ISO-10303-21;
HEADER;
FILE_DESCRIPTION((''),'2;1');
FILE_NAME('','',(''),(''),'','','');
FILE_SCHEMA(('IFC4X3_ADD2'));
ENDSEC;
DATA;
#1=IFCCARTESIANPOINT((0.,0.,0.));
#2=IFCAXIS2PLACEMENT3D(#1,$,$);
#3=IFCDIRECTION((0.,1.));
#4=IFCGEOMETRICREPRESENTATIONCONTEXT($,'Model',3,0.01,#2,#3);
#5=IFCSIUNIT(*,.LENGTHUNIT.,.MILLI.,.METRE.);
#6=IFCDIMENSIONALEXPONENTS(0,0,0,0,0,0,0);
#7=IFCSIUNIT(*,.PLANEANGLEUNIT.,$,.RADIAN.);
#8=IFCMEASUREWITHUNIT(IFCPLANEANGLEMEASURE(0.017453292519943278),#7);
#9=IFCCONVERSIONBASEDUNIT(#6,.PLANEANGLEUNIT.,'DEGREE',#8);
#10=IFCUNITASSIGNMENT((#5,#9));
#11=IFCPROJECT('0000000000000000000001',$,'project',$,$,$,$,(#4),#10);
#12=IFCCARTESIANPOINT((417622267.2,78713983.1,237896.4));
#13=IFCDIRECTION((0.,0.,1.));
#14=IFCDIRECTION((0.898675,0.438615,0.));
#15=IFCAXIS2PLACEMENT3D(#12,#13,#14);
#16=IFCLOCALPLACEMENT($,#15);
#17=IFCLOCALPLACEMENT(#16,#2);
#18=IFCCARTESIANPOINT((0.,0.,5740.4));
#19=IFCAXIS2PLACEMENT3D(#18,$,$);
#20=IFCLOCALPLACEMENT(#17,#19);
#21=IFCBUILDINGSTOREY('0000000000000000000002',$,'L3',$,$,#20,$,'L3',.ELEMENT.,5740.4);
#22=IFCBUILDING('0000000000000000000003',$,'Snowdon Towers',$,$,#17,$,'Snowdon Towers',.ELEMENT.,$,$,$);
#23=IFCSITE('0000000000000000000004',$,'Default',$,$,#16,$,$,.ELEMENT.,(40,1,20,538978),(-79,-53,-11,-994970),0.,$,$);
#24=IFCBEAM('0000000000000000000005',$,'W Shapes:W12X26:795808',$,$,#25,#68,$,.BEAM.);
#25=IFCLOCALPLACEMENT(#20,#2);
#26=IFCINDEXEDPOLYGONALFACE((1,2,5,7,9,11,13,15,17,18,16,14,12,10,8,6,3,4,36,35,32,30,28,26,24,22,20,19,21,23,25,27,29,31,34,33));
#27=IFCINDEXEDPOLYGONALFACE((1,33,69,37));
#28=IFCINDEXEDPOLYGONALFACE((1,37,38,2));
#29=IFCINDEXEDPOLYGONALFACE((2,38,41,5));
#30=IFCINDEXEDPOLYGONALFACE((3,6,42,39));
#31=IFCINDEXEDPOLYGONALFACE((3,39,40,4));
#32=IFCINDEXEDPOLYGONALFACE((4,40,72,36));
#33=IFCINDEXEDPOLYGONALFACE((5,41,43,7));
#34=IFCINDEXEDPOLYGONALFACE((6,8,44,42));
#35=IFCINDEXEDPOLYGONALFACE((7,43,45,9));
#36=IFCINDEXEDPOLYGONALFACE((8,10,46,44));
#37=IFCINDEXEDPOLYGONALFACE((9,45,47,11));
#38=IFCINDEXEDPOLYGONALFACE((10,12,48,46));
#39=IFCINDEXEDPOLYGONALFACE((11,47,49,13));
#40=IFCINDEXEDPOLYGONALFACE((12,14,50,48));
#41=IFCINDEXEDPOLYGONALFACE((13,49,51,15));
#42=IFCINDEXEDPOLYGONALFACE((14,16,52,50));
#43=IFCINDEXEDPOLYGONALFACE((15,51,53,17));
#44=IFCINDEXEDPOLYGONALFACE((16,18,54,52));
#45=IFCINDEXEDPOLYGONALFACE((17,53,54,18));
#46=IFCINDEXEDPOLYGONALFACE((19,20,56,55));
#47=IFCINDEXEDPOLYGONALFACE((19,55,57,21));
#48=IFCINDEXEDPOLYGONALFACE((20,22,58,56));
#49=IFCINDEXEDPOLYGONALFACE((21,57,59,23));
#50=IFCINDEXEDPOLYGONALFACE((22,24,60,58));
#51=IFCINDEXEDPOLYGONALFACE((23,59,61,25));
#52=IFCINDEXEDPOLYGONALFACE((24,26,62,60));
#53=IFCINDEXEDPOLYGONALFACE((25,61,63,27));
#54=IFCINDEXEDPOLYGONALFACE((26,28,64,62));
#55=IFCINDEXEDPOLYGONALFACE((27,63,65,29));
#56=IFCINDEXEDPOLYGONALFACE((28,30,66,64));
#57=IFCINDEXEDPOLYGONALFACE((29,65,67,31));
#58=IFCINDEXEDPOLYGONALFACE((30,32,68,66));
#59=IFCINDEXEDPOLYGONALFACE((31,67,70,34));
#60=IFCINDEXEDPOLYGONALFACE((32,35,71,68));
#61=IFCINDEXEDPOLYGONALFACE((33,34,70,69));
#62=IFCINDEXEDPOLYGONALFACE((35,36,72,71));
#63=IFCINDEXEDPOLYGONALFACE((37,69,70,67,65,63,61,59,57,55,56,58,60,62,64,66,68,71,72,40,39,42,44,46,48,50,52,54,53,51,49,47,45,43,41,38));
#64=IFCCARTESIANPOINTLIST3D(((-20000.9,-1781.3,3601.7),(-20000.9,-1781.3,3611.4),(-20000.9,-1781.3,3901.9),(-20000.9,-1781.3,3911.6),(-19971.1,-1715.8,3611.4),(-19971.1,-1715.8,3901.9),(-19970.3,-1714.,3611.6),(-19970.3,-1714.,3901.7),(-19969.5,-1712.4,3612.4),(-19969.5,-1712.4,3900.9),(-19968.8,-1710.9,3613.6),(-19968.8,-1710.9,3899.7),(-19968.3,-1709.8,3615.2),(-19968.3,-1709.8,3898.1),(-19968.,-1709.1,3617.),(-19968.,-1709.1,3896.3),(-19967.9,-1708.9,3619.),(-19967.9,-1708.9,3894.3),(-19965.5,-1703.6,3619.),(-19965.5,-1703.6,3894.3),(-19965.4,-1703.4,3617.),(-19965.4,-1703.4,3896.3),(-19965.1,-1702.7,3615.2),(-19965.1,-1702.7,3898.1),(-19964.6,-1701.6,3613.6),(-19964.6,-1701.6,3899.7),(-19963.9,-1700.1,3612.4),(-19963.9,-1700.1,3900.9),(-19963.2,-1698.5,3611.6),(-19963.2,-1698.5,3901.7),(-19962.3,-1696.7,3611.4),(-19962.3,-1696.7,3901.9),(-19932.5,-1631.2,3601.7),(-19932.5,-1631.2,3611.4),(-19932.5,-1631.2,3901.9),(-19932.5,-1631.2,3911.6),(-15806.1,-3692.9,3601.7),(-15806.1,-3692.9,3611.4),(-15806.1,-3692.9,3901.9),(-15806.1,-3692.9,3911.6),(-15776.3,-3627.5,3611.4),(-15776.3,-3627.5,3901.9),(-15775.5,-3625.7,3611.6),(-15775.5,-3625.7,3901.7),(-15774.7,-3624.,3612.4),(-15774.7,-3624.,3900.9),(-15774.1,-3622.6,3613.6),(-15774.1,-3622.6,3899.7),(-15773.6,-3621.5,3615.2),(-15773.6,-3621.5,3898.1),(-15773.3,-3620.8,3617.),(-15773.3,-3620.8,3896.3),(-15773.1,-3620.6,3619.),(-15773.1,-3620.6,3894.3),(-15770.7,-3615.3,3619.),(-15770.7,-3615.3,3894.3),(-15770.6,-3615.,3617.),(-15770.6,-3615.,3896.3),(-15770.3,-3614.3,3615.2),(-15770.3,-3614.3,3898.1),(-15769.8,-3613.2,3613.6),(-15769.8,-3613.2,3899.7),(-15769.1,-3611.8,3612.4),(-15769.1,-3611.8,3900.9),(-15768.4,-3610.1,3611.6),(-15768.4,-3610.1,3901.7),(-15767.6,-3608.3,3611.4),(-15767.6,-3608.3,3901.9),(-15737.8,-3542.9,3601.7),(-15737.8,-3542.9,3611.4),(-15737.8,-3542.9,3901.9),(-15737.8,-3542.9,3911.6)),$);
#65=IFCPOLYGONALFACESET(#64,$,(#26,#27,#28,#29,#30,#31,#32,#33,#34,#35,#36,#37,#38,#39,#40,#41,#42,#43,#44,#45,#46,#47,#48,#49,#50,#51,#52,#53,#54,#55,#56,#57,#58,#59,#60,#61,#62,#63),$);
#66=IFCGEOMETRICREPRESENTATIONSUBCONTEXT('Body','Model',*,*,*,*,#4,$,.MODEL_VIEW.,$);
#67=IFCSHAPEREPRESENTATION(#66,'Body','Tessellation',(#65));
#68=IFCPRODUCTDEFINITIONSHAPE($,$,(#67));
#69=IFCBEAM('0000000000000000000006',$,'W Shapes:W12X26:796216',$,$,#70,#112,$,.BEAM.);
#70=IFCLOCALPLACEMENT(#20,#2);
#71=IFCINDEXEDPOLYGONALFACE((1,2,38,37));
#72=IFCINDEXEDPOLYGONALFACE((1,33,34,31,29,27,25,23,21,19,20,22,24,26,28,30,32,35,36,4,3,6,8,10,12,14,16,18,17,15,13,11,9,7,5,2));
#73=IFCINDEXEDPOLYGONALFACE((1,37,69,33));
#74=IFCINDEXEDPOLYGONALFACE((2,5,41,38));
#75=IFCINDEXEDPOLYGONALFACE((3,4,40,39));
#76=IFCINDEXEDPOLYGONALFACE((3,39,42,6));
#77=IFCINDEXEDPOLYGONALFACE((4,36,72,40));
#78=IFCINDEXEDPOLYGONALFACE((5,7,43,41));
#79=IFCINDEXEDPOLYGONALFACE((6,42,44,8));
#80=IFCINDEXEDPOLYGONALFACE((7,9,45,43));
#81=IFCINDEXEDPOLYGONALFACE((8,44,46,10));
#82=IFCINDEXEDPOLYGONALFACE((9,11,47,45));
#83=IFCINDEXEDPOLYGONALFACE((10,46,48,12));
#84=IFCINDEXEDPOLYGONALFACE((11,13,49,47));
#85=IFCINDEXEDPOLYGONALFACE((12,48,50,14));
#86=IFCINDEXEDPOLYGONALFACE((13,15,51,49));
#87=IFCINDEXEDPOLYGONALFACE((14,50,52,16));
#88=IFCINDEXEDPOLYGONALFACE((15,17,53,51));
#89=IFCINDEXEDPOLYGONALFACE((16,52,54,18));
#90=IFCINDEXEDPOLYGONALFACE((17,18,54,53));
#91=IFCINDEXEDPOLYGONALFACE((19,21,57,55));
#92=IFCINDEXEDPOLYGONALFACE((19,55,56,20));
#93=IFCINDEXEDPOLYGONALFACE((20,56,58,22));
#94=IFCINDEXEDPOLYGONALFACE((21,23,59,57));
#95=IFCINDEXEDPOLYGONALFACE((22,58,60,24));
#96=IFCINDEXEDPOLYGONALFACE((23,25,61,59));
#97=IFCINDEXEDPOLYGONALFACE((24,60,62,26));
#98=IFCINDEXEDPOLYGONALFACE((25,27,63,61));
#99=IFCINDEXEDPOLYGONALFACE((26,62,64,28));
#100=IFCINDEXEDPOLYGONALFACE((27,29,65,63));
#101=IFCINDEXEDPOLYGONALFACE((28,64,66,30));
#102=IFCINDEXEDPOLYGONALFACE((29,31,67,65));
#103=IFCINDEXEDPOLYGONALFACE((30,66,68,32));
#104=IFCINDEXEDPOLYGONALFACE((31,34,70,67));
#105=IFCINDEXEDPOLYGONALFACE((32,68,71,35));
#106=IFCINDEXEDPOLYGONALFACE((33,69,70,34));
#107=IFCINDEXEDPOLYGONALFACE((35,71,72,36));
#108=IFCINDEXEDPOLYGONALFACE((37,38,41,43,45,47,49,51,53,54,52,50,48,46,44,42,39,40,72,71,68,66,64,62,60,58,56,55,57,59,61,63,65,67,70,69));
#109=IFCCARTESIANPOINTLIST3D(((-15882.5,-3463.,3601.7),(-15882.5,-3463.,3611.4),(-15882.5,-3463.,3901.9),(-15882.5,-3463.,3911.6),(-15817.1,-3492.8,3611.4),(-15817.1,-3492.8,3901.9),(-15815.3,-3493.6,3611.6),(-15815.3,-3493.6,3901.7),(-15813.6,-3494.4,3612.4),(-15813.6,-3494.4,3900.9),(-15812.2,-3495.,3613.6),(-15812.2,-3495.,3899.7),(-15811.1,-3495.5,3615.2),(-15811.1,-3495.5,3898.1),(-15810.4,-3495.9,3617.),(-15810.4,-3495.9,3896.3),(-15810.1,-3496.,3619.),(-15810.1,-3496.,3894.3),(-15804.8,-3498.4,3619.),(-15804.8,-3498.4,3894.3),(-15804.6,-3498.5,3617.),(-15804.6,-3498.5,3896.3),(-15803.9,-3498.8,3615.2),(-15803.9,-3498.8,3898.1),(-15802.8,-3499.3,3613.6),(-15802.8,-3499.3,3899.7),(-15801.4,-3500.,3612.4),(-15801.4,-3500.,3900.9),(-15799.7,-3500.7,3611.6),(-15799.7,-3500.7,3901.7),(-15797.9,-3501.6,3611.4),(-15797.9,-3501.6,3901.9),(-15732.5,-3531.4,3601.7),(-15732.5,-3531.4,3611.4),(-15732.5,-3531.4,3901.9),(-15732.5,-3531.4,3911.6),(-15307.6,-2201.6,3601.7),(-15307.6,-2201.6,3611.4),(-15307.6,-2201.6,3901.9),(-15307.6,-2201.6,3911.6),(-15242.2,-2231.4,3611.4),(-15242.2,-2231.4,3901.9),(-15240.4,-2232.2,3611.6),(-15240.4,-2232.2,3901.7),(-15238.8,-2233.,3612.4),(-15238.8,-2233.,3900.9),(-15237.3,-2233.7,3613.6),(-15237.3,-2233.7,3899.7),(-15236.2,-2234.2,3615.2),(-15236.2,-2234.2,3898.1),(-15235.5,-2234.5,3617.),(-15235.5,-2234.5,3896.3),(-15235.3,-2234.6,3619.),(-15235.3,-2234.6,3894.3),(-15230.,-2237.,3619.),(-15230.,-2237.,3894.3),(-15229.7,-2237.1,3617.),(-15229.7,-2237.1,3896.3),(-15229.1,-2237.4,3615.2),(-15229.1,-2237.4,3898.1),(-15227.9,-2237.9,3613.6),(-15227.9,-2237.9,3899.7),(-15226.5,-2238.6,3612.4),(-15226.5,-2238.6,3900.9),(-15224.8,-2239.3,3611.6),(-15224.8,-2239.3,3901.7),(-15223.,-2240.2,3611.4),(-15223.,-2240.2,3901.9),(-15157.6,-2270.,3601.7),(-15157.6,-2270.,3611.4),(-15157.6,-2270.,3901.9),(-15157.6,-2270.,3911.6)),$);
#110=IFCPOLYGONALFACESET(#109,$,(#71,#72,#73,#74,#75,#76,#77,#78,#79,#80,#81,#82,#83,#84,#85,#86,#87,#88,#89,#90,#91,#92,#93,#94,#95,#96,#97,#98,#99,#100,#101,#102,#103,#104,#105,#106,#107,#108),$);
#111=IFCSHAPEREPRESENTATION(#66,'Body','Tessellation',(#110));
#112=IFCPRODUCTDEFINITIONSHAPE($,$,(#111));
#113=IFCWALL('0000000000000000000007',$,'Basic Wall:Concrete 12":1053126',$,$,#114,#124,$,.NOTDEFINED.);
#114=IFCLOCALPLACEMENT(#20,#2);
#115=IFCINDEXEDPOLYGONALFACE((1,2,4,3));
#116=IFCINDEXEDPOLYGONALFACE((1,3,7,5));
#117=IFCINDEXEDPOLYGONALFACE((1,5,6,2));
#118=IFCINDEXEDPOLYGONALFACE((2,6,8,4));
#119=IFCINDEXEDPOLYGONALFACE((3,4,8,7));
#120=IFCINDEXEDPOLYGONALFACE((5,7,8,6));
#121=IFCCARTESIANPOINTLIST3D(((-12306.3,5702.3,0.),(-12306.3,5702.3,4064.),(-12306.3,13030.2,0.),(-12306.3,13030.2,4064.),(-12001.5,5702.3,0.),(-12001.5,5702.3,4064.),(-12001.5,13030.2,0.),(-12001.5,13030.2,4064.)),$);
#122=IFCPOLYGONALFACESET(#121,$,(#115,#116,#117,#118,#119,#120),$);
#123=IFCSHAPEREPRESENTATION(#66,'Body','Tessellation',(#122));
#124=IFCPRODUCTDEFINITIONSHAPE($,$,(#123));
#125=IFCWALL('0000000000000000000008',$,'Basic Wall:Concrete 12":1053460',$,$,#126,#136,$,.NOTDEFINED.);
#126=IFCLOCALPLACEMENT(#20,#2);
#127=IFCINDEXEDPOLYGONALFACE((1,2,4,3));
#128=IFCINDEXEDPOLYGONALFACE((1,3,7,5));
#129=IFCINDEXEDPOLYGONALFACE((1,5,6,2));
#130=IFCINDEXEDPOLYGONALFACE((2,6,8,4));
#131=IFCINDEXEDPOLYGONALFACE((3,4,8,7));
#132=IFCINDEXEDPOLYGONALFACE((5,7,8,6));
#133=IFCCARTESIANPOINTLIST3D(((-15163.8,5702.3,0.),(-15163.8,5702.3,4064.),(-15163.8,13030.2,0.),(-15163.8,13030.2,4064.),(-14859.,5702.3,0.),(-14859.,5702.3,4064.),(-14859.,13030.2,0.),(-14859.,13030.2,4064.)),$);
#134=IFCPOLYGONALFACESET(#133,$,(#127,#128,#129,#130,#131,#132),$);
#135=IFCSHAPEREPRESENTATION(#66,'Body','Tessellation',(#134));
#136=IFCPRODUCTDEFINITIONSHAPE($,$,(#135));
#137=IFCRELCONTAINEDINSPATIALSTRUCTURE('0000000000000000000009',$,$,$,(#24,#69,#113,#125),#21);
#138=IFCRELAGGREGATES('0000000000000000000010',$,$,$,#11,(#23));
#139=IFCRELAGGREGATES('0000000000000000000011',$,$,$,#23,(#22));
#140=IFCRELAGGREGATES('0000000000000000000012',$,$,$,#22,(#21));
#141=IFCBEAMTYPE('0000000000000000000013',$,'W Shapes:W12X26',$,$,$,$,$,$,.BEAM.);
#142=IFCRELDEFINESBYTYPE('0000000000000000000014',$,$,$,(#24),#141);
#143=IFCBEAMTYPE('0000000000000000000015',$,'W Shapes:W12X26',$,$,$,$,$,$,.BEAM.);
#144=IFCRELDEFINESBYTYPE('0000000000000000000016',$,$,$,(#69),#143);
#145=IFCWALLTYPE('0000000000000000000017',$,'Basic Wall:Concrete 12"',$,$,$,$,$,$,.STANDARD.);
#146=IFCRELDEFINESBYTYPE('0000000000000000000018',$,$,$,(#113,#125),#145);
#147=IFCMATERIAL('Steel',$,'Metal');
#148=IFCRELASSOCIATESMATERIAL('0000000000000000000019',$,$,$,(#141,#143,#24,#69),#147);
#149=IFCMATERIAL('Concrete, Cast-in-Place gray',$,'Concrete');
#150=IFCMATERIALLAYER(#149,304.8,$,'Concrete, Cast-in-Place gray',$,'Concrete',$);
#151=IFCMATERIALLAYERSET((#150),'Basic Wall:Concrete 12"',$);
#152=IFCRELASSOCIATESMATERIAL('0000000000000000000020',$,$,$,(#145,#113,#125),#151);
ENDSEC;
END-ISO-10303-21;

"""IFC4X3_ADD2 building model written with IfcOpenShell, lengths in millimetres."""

from ifc_helpers import new_model, entity, si_unit, converted_unit, direction, frame, frame_2d, origin, place, context, subcontext, project, spatial, polyline, circle_curve, parameter, trimmed, segment, composite_curve, rectangle, outline, extrude, source, transform, mapped, material, layer, layer_set, material_profile, profile_set, profile_usage, type_object, type_shapes, element, save


model = new_model("IFC4X3_ADD2")

# Units and contexts
model_context = context("Model", 3, precision=0.01, world=origin(), true_north=direction((0.0, 1.0)))
body_context = subcontext(model_context, "Body", "Model", "MODEL_VIEW")
ifc_project = project(units=[si_unit("LENGTHUNIT", "METRE", prefix="MILLI"), converted_unit("PLANEANGLEUNIT", "DEGREE", entity("IfcPlaneAngleMeasure", 0.017453292519943278), si_unit("PLANEANGLEUNIT", "RADIAN"), dimensions=[0, 0, 0, 0, 0, 0, 0])], contexts=[model_context])

# Site, building, storey
site_placement = place(None, frame((417622267.2, 78713983.1, 237896.4), z_axis=(0.0, 0.0, 1.0), x_axis=(0.898675, 0.438615, 0.0)))
site = spatial("IfcSite", under=ifc_project, at=site_placement, Name="Default", CompositionType="ELEMENT", RefLatitude=(40, 1, 20, 538978), RefLongitude=(-79, -53, -11, -994970), RefElevation=0.0)
building_placement = place(site_placement, origin())
building = spatial("IfcBuilding", under=site, at=building_placement, Name="Snowdon Towers", LongName="Snowdon Towers", CompositionType="ELEMENT")
storey_placement = place(building_placement, frame((0.0, 0.0, 5740.4)))
storey = spatial("IfcBuildingStorey", under=building, at=storey_placement, Name="L3", LongName="L3", CompositionType="ELEMENT", Elevation=5740.4)

# Shared definitions
ifc_material_1 = material(Name="Steel", Category="Metal")

# Beams
ifc_material_profile_1 = material_profile(ifc_material_1, outline(composite_curve([segment(polyline([(-82.4, -145.3), (-82.4, -154.9)]), True, "CONTINUOUS"), segment(polyline([(-82.4, -154.9), (82.4, -154.9)]), True, "CONTINUOUS"), segment(polyline([(82.4, -154.9), (82.4, -145.3)]), True, "CONTINUOUS"), segment(polyline([(82.4, -145.3), (10.5, -145.3)]), True, "CONTINUOUS"), segment(trimmed(circle_curve(frame_2d((10.5, -137.7), x_axis=(1.0, 0.0)), 7.6), [parameter(180.0)], [parameter(270.0)], True, "PARAMETER"), False, "CONTINUOUS"), segment(polyline([(2.9, -137.7), (2.9, 137.7)]), True, "CONTINUOUS"), segment(trimmed(circle_curve(frame_2d((10.5, 137.7), x_axis=(1.0, 0.0)), 7.6), [parameter(90.0)], [parameter(180.0)], True, "PARAMETER"), False, "CONTINUOUS"), segment(polyline([(10.5, 145.3), (82.4, 145.3)]), True, "CONTINUOUS"), segment(polyline([(82.4, 145.3), (82.4, 154.9)]), True, "CONTINUOUS"), segment(polyline([(82.4, 154.9), (-82.4, 154.9)]), True, "CONTINUOUS"), segment(polyline([(-82.4, 154.9), (-82.4, 145.3)]), True, "CONTINUOUS"), segment(polyline([(-82.4, 145.3), (-10.5, 145.3)]), True, "CONTINUOUS"), segment(trimmed(circle_curve(frame_2d((-10.5, 137.7), x_axis=(1.0, 0.0)), 7.6), [parameter(360.0)], [parameter(90.0)], True, "PARAMETER"), False, "CONTINUOUS"), segment(polyline([(-2.9, 137.7), (-2.9, -137.7)]), True, "CONTINUOUS"), segment(trimmed(circle_curve(frame_2d((-10.5, -137.7), x_axis=(1.0, 0.0)), 7.6), [parameter(270.0)], [parameter(360.0)], True, "PARAMETER"), False, "CONTINUOUS"), segment(polyline([(-10.5, -145.3), (-82.4, -145.3)]), True, "CONTINUOUS")], self_intersect=False)), Name="W12X26")
ifc_profile_set_1 = profile_set([ifc_material_profile_1], Name="W12X26")
ifc_profile_usage_1 = profile_usage(ifc_profile_set_1, cardinal=8)
beam_type_1 = type_object("IfcBeamType", Name="W Shapes:W12X26", PredefinedType="BEAM", material=ifc_profile_set_1)
shared_shape_1 = source(origin(), body_context, "Body", "SweptSolid", [
    extrude(outline(composite_curve([segment(polyline([(-82.4, -145.3), (-82.4, -154.9)]), True, "CONTINUOUS"), segment(polyline([(-82.4, -154.9), (82.4, -154.9)]), True, "CONTINUOUS"), segment(polyline([(82.4, -154.9), (82.4, -145.3)]), True, "CONTINUOUS"), segment(polyline([(82.4, -145.3), (10.5, -145.3)]), True, "CONTINUOUS"), segment(trimmed(circle_curve(frame_2d((10.5, -137.7), x_axis=(0.0, -1.0)), 7.6), [parameter(270.0)], [parameter(360.0)], True, "PARAMETER"), False, "CONTINUOUS"), segment(polyline([(2.9, -137.7), (2.9, 137.7)]), True, "CONTINUOUS"), segment(trimmed(circle_curve(frame_2d((10.5, 137.7), x_axis=(-1.0, 0.0)), 7.6), [parameter(270.0)], [parameter(360.0)], True, "PARAMETER"), False, "CONTINUOUS"), segment(polyline([(10.5, 145.3), (82.4, 145.3)]), True, "CONTINUOUS"), segment(polyline([(82.4, 145.3), (82.4, 154.9)]), True, "CONTINUOUS"), segment(polyline([(82.4, 154.9), (-82.4, 154.9)]), True, "CONTINUOUS"), segment(polyline([(-82.4, 154.9), (-82.4, 145.3)]), True, "CONTINUOUS"), segment(polyline([(-82.4, 145.3), (-10.5, 145.3)]), True, "CONTINUOUS"), segment(trimmed(circle_curve(frame_2d((-10.5, 137.7), x_axis=(0.0, 1.0)), 7.6), [parameter(270.0)], [parameter(0.0)], True, "PARAMETER"), False, "CONTINUOUS"), segment(polyline([(-2.9, 137.7), (-2.9, -137.7)]), True, "CONTINUOUS"), segment(trimmed(circle_curve(frame_2d((-10.5, -137.7), x_axis=(1.0, 0.0)), 7.6), [parameter(270.0)], [parameter(0.0)], True, "PARAMETER"), False, "CONTINUOUS"), segment(polyline([(-10.5, -145.3), (-82.4, -145.3)]), True, "CONTINUOUS")], self_intersect=False)), frame((-2304.9, 0.0, 0.0), z_axis=(-1.0, 0.0, 0.0), x_axis=(0.0, -1.0, 0.0)), (0.0, 0.0, -1.0), 4609.8),
])
type_shapes(beam_type_1, [shared_shape_1])
beam_1_placement = place(storey_placement, frame((-17869.3, -2662.1, 3756.7), z_axis=(0.0, 0.0, 1.0), x_axis=(0.909961, -0.414693, 0.0)))
element("IfcBeam", 1, at=beam_1_placement, inside=storey, type_object=beam_type_1, material=ifc_profile_usage_1, Name="W Shapes:W12X26:795808", PredefinedType="BEAM", context=body_context, shape_type="MappedRepresentation", body=[
    mapped(shared_shape_1, transform((0.0, 0.0, 0.0), scale=1.0)),
])
beam_type_2 = type_object("IfcBeamType", Name="W Shapes:W12X26", PredefinedType="BEAM", material=ifc_profile_set_1)
shared_shape_2 = source(origin(), body_context, "Body", "SweptSolid", [
    extrude(outline(composite_curve([segment(polyline([(-82.4, -145.3), (-82.4, -154.9)]), True, "CONTINUOUS"), segment(polyline([(-82.4, -154.9), (82.4, -154.9)]), True, "CONTINUOUS"), segment(polyline([(82.4, -154.9), (82.4, -145.3)]), True, "CONTINUOUS"), segment(polyline([(82.4, -145.3), (10.5, -145.3)]), True, "CONTINUOUS"), segment(trimmed(circle_curve(frame_2d((10.5, -137.7), x_axis=(1.0, 0.0)), 7.6), [parameter(180.0)], [parameter(270.0)], True, "PARAMETER"), False, "CONTINUOUS"), segment(polyline([(2.9, -137.7), (2.9, 137.7)]), True, "CONTINUOUS"), segment(trimmed(circle_curve(frame_2d((10.5, 137.7), x_axis=(1.0, 0.0)), 7.6), [parameter(90.0)], [parameter(180.0)], True, "PARAMETER"), False, "CONTINUOUS"), segment(polyline([(10.5, 145.3), (82.4, 145.3)]), True, "CONTINUOUS"), segment(polyline([(82.4, 145.3), (82.4, 154.9)]), True, "CONTINUOUS"), segment(polyline([(82.4, 154.9), (-82.4, 154.9)]), True, "CONTINUOUS"), segment(polyline([(-82.4, 154.9), (-82.4, 145.3)]), True, "CONTINUOUS"), segment(polyline([(-82.4, 145.3), (-10.5, 145.3)]), True, "CONTINUOUS"), segment(trimmed(circle_curve(frame_2d((-10.5, 137.7), x_axis=(1.0, 0.0)), 7.6), [parameter(360.0)], [parameter(90.0)], True, "PARAMETER"), False, "CONTINUOUS"), segment(polyline([(-2.9, 137.7), (-2.9, -137.7)]), True, "CONTINUOUS"), segment(trimmed(circle_curve(frame_2d((-10.5, -137.7), x_axis=(1.0, 0.0)), 7.6), [parameter(270.0)], [parameter(360.0)], True, "PARAMETER"), False, "CONTINUOUS"), segment(polyline([(-10.5, -145.3), (-82.4, -145.3)]), True, "CONTINUOUS")], self_intersect=False)), frame((-878.4, 0.0, 0.0), z_axis=(-1.0, 0.0, 0.0), x_axis=(0.0, -1.0, 0.0)), (0.0, 0.0, -1.0), 1386.2),
])
type_shapes(beam_type_2, [shared_shape_2])
beam_2_placement = place(storey_placement, frame((-15443.2, -2697.8, 3756.7), z_axis=(0.0, 0.0, 1.0), x_axis=(0.414693, 0.909961, 0.0)))
element("IfcBeam", 2, at=beam_2_placement, inside=storey, type_object=beam_type_2, material=ifc_profile_usage_1, Name="W Shapes:W12X26:796216", PredefinedType="BEAM", context=body_context, shape_type="MappedRepresentation", body=[
    mapped(shared_shape_2, transform((0.0, 0.0, 0.0), scale=1.0)),
])

# Walls
ifc_material_2 = material(Name="Concrete, Cast-in-Place gray", Category="Concrete")
ifc_layer = layer(ifc_material_2, 304.8, Name="Concrete, Cast-in-Place gray", Category="Concrete")
ifc_layer_set = layer_set([ifc_layer], Name="Basic Wall:Concrete 12\"")
wall_type = type_object("IfcWallType", Name="Basic Wall:Concrete 12\"", PredefinedType="STANDARD", material=ifc_layer_set)
wall_1_placement = place(storey_placement, frame((-12153.9, 5702.3, 0.0), z_axis=(0.0, 0.0, 1.0), x_axis=(0.0, 1.0, 0.0)))
element("IfcWall", 3, at=wall_1_placement, inside=storey, type_object=wall_type, material=ifc_layer_set, Name="Basic Wall:Concrete 12\":1053126", PredefinedType="NOTDEFINED", context=body_context, shape_type="SweptSolid", body=[
    extrude(rectangle(XDim=7327.9, YDim=304.8, at=frame_2d((3663.9, 0.0), x_axis=(-1.0, 0.0))), origin(), (0.0, 0.0, 1.0), 4064.0),
])
wall_2_placement = place(storey_placement, frame((-15011.4, 13030.2, 0.0), z_axis=(0.0, 0.0, 1.0), x_axis=(0.0, -1.0, 0.0)))
element("IfcWall", 4, at=wall_2_placement, inside=storey, type_object=wall_type, material=ifc_layer_set, Name="Basic Wall:Concrete 12\":1053460", PredefinedType="NOTDEFINED", context=body_context, shape_type="SweptSolid", body=[
    extrude(rectangle(XDim=7327.9, YDim=304.8, at=frame_2d((3663.9, 0.0), x_axis=(-1.0, 0.0))), origin(), (0.0, 0.0, 1.0), 4064.0),
])

save(model, "model.ifc")
